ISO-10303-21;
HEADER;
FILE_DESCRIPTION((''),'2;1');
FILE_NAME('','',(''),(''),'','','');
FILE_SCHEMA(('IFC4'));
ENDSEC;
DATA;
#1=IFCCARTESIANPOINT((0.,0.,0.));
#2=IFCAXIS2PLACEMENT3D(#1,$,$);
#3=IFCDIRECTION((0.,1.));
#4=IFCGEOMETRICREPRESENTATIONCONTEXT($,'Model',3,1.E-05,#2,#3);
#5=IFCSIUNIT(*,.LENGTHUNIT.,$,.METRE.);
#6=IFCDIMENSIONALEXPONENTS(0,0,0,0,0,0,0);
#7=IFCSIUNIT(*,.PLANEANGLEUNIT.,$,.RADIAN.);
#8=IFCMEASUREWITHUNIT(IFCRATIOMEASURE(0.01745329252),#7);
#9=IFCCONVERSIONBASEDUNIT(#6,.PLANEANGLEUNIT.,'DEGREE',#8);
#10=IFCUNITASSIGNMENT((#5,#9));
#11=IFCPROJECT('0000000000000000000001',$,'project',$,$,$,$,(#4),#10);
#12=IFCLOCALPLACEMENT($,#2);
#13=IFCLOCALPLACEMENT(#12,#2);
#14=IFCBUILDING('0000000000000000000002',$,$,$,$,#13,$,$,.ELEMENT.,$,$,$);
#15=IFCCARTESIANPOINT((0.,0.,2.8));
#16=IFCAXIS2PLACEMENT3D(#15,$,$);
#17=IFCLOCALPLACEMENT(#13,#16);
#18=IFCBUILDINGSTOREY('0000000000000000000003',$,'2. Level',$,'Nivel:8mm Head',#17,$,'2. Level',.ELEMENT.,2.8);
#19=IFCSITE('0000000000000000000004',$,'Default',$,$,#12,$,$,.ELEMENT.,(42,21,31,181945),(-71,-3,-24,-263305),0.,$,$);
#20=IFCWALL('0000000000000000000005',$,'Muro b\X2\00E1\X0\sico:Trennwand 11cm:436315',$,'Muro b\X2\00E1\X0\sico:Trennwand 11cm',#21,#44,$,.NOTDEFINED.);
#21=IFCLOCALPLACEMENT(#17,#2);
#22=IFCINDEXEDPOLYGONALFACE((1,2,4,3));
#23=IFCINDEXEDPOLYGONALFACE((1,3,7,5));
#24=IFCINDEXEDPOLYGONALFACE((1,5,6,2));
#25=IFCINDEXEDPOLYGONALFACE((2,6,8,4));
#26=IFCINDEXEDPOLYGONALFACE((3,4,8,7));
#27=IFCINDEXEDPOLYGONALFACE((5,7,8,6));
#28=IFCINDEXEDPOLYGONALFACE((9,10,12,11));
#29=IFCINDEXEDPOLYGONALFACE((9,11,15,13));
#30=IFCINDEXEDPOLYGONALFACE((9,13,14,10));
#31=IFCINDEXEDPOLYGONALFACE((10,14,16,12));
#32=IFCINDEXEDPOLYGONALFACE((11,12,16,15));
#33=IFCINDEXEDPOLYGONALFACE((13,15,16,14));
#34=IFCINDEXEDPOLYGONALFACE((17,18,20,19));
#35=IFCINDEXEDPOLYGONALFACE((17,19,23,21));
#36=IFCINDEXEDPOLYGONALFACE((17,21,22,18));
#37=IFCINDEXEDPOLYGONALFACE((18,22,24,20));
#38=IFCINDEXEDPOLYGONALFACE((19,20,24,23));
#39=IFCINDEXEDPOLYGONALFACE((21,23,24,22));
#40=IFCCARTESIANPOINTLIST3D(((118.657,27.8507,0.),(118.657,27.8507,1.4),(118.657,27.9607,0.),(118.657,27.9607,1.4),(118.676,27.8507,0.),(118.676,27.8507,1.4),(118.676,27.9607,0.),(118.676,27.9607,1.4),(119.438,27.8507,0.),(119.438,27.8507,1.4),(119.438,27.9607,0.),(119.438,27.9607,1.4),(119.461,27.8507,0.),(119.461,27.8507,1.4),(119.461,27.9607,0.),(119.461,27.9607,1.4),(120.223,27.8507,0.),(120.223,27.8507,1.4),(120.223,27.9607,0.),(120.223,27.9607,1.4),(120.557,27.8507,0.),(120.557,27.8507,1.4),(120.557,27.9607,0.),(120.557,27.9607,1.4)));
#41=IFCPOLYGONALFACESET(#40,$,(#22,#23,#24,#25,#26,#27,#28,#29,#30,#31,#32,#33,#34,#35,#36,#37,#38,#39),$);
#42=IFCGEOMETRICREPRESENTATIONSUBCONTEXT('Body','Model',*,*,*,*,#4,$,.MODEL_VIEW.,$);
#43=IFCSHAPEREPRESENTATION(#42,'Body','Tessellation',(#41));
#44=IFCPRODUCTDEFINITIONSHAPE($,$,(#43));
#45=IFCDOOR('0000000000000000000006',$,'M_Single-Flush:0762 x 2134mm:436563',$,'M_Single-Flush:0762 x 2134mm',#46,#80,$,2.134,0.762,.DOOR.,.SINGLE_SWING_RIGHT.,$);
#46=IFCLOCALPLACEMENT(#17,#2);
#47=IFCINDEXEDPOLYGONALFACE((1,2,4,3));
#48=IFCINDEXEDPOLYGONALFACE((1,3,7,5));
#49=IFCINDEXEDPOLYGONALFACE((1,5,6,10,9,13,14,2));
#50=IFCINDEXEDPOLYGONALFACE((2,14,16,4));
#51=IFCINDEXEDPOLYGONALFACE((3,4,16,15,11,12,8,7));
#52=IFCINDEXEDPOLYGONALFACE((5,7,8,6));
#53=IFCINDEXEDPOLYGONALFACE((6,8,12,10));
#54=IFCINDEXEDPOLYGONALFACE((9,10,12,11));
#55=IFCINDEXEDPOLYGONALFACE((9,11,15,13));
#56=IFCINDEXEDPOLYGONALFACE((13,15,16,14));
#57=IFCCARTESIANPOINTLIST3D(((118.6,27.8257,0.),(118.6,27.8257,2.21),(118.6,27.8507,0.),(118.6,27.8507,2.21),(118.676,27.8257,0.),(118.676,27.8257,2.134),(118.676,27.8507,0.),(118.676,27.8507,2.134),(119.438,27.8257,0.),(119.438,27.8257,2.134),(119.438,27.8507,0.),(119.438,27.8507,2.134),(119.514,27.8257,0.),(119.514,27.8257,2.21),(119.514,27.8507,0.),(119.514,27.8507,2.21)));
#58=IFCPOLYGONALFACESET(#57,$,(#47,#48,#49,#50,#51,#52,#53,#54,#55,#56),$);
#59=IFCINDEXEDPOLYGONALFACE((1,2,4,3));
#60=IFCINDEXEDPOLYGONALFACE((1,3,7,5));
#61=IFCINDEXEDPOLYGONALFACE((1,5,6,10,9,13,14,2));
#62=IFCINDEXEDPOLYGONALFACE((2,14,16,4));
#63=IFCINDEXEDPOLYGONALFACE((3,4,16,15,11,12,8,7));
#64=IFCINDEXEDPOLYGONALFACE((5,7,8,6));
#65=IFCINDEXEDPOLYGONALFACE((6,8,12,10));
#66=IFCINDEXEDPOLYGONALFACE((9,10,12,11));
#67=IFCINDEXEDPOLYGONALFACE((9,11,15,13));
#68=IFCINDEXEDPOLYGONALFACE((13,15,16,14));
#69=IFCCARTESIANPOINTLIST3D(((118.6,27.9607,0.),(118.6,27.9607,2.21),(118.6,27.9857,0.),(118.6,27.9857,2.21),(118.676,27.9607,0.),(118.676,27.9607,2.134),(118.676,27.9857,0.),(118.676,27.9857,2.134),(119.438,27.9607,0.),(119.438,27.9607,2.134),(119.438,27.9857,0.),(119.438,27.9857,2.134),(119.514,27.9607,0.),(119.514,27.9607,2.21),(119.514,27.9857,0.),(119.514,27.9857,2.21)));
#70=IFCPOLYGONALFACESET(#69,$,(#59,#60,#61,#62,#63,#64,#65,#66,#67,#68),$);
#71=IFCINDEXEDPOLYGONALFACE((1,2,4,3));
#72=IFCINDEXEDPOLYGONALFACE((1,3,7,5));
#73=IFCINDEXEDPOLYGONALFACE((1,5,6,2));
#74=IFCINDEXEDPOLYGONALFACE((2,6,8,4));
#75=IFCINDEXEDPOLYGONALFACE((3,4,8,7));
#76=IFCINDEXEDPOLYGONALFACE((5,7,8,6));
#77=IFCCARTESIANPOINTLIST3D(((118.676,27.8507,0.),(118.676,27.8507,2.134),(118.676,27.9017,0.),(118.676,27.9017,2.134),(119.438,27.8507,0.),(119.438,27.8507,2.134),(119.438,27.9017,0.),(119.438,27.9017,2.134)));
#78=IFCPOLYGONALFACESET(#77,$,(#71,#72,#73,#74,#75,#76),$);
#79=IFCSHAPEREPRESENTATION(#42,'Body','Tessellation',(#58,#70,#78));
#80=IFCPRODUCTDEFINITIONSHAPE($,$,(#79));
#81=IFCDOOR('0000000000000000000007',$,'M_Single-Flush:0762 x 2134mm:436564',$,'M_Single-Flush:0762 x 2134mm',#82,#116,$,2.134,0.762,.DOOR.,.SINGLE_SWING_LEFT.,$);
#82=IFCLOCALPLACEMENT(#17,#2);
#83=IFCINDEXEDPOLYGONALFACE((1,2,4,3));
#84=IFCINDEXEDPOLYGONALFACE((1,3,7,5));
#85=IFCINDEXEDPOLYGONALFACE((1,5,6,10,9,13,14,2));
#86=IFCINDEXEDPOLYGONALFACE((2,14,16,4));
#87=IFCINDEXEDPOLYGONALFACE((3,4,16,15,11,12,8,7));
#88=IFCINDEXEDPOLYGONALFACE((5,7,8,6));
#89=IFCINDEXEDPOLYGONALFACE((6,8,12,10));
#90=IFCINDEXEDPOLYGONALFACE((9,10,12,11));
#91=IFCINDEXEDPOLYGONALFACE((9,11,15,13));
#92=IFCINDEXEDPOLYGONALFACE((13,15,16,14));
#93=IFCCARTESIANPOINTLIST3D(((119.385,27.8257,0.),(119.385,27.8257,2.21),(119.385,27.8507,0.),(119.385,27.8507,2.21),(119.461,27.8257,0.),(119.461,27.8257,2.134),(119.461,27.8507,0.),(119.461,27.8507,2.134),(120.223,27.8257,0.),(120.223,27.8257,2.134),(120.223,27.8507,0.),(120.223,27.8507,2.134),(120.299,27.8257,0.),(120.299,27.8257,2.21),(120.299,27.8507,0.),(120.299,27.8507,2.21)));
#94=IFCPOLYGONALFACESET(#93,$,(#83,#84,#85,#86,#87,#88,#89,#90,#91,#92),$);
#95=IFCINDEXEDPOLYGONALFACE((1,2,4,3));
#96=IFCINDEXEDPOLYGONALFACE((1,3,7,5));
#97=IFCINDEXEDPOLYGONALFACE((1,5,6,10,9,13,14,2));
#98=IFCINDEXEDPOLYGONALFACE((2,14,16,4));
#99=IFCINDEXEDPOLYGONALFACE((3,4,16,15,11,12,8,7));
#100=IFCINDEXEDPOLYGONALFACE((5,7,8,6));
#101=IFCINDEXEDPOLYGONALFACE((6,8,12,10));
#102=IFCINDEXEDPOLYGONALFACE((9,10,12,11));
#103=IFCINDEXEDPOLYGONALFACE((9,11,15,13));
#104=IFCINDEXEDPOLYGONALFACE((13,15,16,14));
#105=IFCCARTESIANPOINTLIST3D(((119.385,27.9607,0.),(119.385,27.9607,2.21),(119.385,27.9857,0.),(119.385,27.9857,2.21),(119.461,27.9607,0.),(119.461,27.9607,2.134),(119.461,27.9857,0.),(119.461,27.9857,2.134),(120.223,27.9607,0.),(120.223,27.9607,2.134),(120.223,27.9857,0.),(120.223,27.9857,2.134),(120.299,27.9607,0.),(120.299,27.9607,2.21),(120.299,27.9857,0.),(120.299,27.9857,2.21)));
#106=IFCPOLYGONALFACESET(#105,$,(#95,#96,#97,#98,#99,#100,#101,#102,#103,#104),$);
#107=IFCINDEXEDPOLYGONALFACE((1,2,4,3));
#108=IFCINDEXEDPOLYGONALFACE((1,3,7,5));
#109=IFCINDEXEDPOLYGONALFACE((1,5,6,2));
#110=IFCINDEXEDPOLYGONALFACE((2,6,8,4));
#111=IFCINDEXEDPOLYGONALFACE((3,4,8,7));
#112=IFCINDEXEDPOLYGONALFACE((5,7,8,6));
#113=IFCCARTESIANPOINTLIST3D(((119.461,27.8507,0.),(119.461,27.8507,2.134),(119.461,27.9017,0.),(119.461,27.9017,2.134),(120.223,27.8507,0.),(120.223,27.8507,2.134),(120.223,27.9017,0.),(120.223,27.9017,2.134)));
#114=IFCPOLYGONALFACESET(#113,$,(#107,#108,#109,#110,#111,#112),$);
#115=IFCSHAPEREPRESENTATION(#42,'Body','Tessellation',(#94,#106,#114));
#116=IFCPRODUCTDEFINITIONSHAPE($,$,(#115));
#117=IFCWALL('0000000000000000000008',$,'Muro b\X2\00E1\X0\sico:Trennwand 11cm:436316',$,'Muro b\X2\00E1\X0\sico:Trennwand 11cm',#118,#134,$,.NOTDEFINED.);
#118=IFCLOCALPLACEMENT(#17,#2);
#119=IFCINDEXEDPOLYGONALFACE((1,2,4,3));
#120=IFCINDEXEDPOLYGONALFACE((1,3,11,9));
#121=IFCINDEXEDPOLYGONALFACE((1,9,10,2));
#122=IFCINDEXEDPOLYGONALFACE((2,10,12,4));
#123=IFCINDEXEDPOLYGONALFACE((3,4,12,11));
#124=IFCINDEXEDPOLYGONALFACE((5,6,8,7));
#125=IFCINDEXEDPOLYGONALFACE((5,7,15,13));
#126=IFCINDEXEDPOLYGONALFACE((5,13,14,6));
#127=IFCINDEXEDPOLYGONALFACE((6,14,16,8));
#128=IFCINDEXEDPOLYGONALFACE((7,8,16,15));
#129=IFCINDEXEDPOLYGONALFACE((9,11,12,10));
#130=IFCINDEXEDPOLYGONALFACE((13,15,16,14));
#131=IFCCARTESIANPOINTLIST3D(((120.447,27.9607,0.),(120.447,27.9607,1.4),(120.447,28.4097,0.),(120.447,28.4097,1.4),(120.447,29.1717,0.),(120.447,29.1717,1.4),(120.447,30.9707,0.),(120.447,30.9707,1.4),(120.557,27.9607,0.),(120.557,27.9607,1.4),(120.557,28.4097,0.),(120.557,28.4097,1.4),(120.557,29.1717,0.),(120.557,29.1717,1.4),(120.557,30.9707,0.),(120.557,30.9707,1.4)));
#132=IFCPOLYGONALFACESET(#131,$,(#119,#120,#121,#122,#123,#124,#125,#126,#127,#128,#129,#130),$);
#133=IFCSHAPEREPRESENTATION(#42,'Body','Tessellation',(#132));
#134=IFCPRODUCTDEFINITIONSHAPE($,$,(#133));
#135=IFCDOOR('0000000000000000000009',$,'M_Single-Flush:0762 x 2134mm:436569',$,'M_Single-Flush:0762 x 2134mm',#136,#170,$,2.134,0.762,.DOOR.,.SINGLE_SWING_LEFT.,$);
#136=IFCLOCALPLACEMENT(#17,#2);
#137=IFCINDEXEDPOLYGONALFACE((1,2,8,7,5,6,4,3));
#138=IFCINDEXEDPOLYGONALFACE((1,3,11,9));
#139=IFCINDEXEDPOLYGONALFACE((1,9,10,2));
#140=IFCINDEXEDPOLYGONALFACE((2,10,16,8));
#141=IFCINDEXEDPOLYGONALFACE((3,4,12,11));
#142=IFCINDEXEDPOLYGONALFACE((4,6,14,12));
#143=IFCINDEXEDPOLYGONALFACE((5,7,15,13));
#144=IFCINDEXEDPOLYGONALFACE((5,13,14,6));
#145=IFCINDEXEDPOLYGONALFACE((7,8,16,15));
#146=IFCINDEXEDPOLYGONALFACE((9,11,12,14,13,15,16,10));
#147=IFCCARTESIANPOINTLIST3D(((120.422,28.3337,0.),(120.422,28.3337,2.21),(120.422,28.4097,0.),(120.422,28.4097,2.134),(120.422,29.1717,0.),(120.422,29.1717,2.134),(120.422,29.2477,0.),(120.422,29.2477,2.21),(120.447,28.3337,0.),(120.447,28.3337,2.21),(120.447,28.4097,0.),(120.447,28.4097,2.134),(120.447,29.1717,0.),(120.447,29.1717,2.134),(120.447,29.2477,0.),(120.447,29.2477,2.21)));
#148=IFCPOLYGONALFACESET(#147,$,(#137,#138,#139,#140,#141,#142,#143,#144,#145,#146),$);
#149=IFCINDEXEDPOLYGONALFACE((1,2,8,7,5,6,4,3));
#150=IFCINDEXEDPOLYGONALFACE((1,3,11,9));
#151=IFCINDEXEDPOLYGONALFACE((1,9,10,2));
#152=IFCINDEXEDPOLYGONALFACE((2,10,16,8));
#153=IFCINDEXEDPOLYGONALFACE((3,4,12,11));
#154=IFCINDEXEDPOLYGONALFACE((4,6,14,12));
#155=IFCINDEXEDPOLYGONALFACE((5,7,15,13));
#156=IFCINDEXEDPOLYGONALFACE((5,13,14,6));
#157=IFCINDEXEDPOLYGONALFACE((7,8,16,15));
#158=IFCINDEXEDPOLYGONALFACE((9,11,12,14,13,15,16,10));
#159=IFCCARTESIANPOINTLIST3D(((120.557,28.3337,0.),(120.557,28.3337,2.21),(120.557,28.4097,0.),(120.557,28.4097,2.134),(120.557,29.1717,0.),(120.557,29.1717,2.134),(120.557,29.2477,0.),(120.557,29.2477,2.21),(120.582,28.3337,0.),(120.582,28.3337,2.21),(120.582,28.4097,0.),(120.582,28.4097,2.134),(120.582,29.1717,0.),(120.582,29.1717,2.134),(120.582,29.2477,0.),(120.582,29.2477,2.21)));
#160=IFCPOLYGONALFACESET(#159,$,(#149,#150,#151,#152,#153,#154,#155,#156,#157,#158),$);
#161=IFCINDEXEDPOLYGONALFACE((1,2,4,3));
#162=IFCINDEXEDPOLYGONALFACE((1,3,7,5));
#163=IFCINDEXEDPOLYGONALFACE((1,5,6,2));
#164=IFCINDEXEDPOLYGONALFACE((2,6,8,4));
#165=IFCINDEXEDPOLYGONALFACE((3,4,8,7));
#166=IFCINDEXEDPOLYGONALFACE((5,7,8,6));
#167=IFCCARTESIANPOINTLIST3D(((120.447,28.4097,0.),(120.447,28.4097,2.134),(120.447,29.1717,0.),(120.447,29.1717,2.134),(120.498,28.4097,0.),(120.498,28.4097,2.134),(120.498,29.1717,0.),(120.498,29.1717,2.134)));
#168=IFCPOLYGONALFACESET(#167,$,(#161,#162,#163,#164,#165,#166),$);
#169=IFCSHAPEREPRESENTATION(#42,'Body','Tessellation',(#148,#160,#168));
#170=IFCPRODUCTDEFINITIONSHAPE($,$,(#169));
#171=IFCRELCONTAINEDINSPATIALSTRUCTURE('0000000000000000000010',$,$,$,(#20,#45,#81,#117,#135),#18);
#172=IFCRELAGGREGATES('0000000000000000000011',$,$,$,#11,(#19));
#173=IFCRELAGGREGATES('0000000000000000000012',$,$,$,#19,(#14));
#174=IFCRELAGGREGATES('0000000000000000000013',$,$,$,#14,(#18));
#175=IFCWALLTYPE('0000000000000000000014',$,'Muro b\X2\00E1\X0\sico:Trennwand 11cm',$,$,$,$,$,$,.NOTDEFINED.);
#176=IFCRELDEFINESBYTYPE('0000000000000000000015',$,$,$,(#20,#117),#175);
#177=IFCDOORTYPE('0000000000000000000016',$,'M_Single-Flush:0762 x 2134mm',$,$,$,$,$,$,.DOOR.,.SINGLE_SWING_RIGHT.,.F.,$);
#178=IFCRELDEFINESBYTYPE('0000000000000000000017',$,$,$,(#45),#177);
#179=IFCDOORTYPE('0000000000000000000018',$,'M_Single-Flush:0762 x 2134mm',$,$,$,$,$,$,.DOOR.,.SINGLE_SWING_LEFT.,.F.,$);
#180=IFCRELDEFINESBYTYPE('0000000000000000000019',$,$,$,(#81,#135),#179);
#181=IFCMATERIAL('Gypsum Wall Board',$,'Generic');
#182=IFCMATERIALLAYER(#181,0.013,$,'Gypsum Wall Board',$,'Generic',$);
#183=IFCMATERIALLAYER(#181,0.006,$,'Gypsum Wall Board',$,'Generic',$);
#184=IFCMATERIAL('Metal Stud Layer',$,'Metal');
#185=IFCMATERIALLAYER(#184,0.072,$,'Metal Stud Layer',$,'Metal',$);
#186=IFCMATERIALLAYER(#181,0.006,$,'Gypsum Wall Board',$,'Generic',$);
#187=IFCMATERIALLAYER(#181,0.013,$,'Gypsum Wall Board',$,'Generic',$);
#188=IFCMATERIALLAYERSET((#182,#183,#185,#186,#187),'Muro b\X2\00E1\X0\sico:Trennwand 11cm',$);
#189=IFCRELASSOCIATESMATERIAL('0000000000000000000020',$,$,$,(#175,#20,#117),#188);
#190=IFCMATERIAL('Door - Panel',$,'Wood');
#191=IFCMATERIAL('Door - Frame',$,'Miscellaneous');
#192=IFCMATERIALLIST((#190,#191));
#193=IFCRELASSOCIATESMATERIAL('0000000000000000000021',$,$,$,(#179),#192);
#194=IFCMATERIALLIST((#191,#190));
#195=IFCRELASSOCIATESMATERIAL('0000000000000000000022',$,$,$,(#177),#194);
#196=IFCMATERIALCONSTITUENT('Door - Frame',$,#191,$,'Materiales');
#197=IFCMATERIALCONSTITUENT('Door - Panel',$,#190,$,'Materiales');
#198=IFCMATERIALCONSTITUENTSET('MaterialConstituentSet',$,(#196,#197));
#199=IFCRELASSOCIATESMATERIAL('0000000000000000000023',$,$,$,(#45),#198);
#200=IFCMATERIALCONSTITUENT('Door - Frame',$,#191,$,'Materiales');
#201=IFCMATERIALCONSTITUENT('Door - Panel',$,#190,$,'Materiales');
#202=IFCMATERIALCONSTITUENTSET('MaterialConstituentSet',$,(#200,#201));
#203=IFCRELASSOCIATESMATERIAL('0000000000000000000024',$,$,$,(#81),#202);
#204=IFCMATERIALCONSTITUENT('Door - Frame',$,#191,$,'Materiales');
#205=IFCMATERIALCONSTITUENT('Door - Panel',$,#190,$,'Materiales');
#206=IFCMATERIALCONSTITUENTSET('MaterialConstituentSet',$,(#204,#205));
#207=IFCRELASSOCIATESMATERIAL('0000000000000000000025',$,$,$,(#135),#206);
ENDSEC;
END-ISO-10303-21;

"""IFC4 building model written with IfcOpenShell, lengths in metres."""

from ifc_helpers import new_model, entity, si_unit, converted_unit, direction, frame, frame_2d, origin, origin_2d_with_axis, place, context, subcontext, project, spatial, polyline, rectangle, outline, extrude, clip, halfspace, source, transform, mapped, material, material_list, layer, layer_set, layer_usage, constituent, constituent_set, type_object, type_shapes, element, fill, save


model = new_model("IFC4")

# Units and contexts
model_context = context("Model", 3, precision=1e-05, world=origin(), true_north=direction((0.0, 1.0)))
body_context = subcontext(model_context, "Body", "Model", "MODEL_VIEW")
ifc_project = project(units=[si_unit("LENGTHUNIT", "METRE"), converted_unit("PLANEANGLEUNIT", "DEGREE", entity("IfcRatioMeasure", 0.01745329252), si_unit("PLANEANGLEUNIT", "RADIAN"), dimensions=[0, 0, 0, 0, 0, 0, 0])], contexts=[model_context])

# Site, building, storey
site_placement = place(None, origin())
site = spatial("IfcSite", under=ifc_project, at=site_placement, Name="Default", CompositionType="ELEMENT", RefLatitude=(42, 21, 31, 181945), RefLongitude=(-71, -3, -24, -263305), RefElevation=0.0)
building_placement = place(site_placement, origin())
building = spatial("IfcBuilding", under=site, at=building_placement, CompositionType="ELEMENT")
storey_placement = place(building_placement, frame((0.0, 0.0, 2.8)))
storey = spatial("IfcBuildingStorey", under=building, at=storey_placement, Name="2. Level", ObjectType="Nivel:8mm Head", LongName="2. Level", CompositionType="ELEMENT", Elevation=2.8)

# Shared definitions
ifc_material_1 = material(Name="Gypsum Wall Board", Category="Generic")
ifc_layer_1 = layer(ifc_material_1, 0.013, Name="Gypsum Wall Board", Category="Generic")
ifc_layer_2 = layer(ifc_material_1, 0.006, Name="Gypsum Wall Board", Category="Generic")
ifc_material_2 = material(Name="Metal Stud Layer", Category="Metal")
ifc_layer_3 = layer(ifc_material_2, 0.072, Name="Metal Stud Layer", Category="Metal")
ifc_layer_4 = layer(ifc_material_1, 0.006, Name="Gypsum Wall Board", Category="Generic")
ifc_layer_5 = layer(ifc_material_1, 0.013, Name="Gypsum Wall Board", Category="Generic")
ifc_layer_set_1 = layer_set([ifc_layer_1, ifc_layer_2, ifc_layer_3, ifc_layer_4, ifc_layer_5], Name="Muro básico:Trennwand 11cm")
wall_type_1 = type_object("IfcWallType", Name="Muro básico:Trennwand 11cm", PredefinedType="NOTDEFINED", material=ifc_layer_set_1)
ifc_material_3 = material(Name="Door - Frame", Category="Miscellaneous")
ifc_material_4 = material(Name="Door - Panel", Category="Wood")
ifc_material_list_1 = material_list([ifc_material_4, ifc_material_3])
door_type_1 = type_object("IfcDoorType", Name="M_Single-Flush:0762 x 2134mm", OperationType="SINGLE_SWING_LEFT", ParameterTakesPrecedence=False, PredefinedType="DOOR", material=ifc_material_list_1)
shared_shape_1 = source(origin(), body_context, "Body", "SweptSolid", [
    extrude(outline(polyline([(-0.457, -1.124), (0.457, -1.124), (0.457, 1.086), (0.381, 1.086), (0.381, -1.048), (-0.381, -1.048), (-0.381, 1.086), (-0.457, 1.086), (-0.457, -1.124)])), frame((0.381, 0.135, 1.086), z_axis=(0.0, -1.0, 0.0), x_axis=(-1.0, 0.0, 0.0)), (0.0, 0.0, 1.0), 0.025),
    extrude(outline(polyline([(-1.124, -0.457), (1.086, -0.457), (1.086, -0.381), (-1.048, -0.381), (-1.048, 0.381), (1.086, 0.381), (1.086, 0.457), (-1.124, 0.457), (-1.124, -0.457)])), frame((0.381, 0.0, 1.086), z_axis=(0.0, -1.0, 0.0), x_axis=(0.0, 0.0, -1.0)), (0.0, 0.0, 1.0), 0.025),
    extrude(rectangle(XDim=0.762, YDim=0.051, at=origin_2d_with_axis()), frame((0.381, 0.0845, 0.0)), (0.0, 0.0, 1.0), 2.134),
])
type_shapes(door_type_1, [shared_shape_1])

# Wall, openings, doors
ifc_layer_usage_1 = layer_usage(ifc_layer_set_1, "AXIS2", "NEGATIVE", 0.055)
wall_1_placement = place(storey_placement, frame((118.657, 27.9057, 0.0)))
wall_1 = element("IfcWall", 1, at=wall_1_placement, inside=storey, type_object=wall_type_1, material=ifc_layer_usage_1, Name="Muro básico:Trennwand 11cm:436315", ObjectType="Muro básico:Trennwand 11cm", PredefinedType="NOTDEFINED", context=body_context, shape_type="Clipping", body=[
    clip(extrude(rectangle(XDim=1.9, YDim=0.11, at=frame_2d((0.95, 0.0), x_axis=(-1.0, 0.0))), origin(), (0.0, 0.0, 1.0), 1.4), halfspace(origin(), True)),
])
opening_1_placement = place(wall_1_placement, frame((0.781, 0.055, 0.0)))
opening_1 = element("IfcOpeningElement", 2, at=opening_1_placement, cuts=wall_1, ObjectType="Opening", PredefinedType="OPENING", context=body_context, shape_type="SweptSolid", body=[
    extrude(rectangle(XDim=0.762, YDim=2.134, at=frame_2d((1.067, 0.381), x_axis=(0.0, 1.0))), frame((0.0, 0.0, 0.0), z_axis=(0.0, -1.0, 0.0), x_axis=(0.0, 0.0, 1.0)), (0.0, 0.0, 1.0), 0.11),
])
opening_2_placement = place(wall_1_placement, frame((1.566, 0.055, 0.0)))
opening_2 = element("IfcOpeningElement", 3, at=opening_2_placement, cuts=wall_1, ObjectType="Opening", PredefinedType="OPENING", context=body_context, shape_type="SweptSolid", body=[
    extrude(rectangle(XDim=0.762, YDim=2.134, at=frame_2d((1.067, 0.381), x_axis=(0.0, -1.0))), frame((0.0, 0.0, 0.0), z_axis=(0.0, -1.0, 0.0), x_axis=(0.0, 0.0, 1.0)), (0.0, 0.0, 1.0), 0.11),
])
ifc_constituent_1 = constituent(ifc_material_3, Name="Door - Frame", Category="Materiales")
ifc_constituent_2 = constituent(ifc_material_4, Name="Door - Panel", Category="Materiales")
ifc_constituent_set_1 = constituent_set(constituents=[ifc_constituent_1, ifc_constituent_2], Name="MaterialConstituentSet")
ifc_material_list_2 = material_list([ifc_material_3, ifc_material_4])
door_type_2 = type_object("IfcDoorType", Name="M_Single-Flush:0762 x 2134mm", OperationType="SINGLE_SWING_RIGHT", ParameterTakesPrecedence=False, PredefinedType="DOOR", material=ifc_material_list_2)
shared_shape_2 = source(origin(), body_context, "Body", "SweptSolid", [
    extrude(outline(polyline([(-0.457, -1.124), (0.457, -1.124), (0.457, 1.086), (0.381, 1.086), (0.381, -1.048), (-0.381, -1.048), (-0.381, 1.086), (-0.457, 1.086), (-0.457, -1.124)])), frame((0.381, 0.11, 1.086), z_axis=(0.0, 1.0, 0.0), x_axis=(1.0, 0.0, 0.0)), (0.0, 0.0, 1.0), 0.025),
    extrude(outline(polyline([(-1.124, -0.457), (1.086, -0.457), (1.086, -0.381), (-1.048, -0.381), (-1.048, 0.381), (1.086, 0.381), (1.086, 0.457), (-1.124, 0.457), (-1.124, -0.457)])), frame((0.381, -0.025, 1.086), z_axis=(0.0, 1.0, 0.0), x_axis=(0.0, 0.0, -1.0)), (0.0, 0.0, 1.0), 0.025),
    extrude(rectangle(XDim=0.051, YDim=0.762, at=origin_2d_with_axis()), frame((0.381, 0.0845, 0.0), z_axis=(0.0, 0.0, 1.0), x_axis=(0.0, 1.0, 0.0)), (0.0, 0.0, 1.0), 2.134),
])
type_shapes(door_type_2, [shared_shape_2])
door_1_placement = place(opening_1_placement, frame((0.0, 0.0, 0.0), z_axis=(0.0, 0.0, 1.0), x_axis=(-1.0, 0.0, 0.0)))
door_1 = element("IfcDoor", 4, at=door_1_placement, inside=storey, type_object=door_type_2, material=ifc_constituent_set_1, Name="M_Single-Flush:0762 x 2134mm:436563", ObjectType="M_Single-Flush:0762 x 2134mm", OperationType="SINGLE_SWING_RIGHT", OverallHeight=2.134, OverallWidth=0.762, PredefinedType="DOOR", context=body_context, shape_type="MappedRepresentation", body=[
    mapped(shared_shape_2, transform((0.0, 0.0, 0.0), scale=1.0)),
])
fill(opening_1, door_1)
ifc_constituent_3 = constituent(ifc_material_3, Name="Door - Frame", Category="Materiales")
ifc_constituent_4 = constituent(ifc_material_4, Name="Door - Panel", Category="Materiales")
ifc_constituent_set_2 = constituent_set(constituents=[ifc_constituent_3, ifc_constituent_4], Name="MaterialConstituentSet")
door_2_placement = place(opening_2_placement, frame((0.0, 0.0, 0.0), z_axis=(0.0, 0.0, 1.0), x_axis=(-1.0, 0.0, 0.0)))
door_2 = element("IfcDoor", 5, at=door_2_placement, inside=storey, type_object=door_type_1, material=ifc_constituent_set_2, Name="M_Single-Flush:0762 x 2134mm:436564", ObjectType="M_Single-Flush:0762 x 2134mm", OperationType="SINGLE_SWING_LEFT", OverallHeight=2.134, OverallWidth=0.762, PredefinedType="DOOR", context=body_context, shape_type="MappedRepresentation", body=[
    mapped(shared_shape_1, transform((0.0, 0.0, 0.0), scale=1.0)),
])
fill(opening_2, door_2)

# Wall, opening, door
ifc_layer_usage_2 = layer_usage(ifc_layer_set_1, "AXIS2", "NEGATIVE", 0.055)
wall_2_placement = place(storey_placement, frame((120.502, 27.9607, 0.0), z_axis=(0.0, 0.0, 1.0), x_axis=(0.0, 1.0, 0.0)))
wall_2 = element("IfcWall", 6, at=wall_2_placement, inside=storey, type_object=wall_type_1, material=ifc_layer_usage_2, Name="Muro básico:Trennwand 11cm:436316", ObjectType="Muro básico:Trennwand 11cm", PredefinedType="NOTDEFINED", context=body_context, shape_type="Clipping", body=[
    clip(extrude(rectangle(XDim=3.01, YDim=0.11, at=frame_2d((1.505, 0.0), x_axis=(-1.0, 0.0))), origin(), (0.0, 0.0, 1.0), 1.4), halfspace(origin(), True)),
])
opening_3_placement = place(wall_2_placement, frame((0.449, -0.055, 0.0)))
opening_3 = element("IfcOpeningElement", 7, at=opening_3_placement, cuts=wall_2, ObjectType="Opening", PredefinedType="OPENING", context=body_context, shape_type="SweptSolid", body=[
    extrude(rectangle(XDim=0.762, YDim=2.134, at=frame_2d((1.067, 0.381), x_axis=(0.0, -1.0))), frame((0.0, 0.0, 0.0), z_axis=(0.0, 1.0, 0.0), x_axis=(0.0, 0.0, 1.0)), (0.0, 0.0, 1.0), 0.11),
])
ifc_constituent_5 = constituent(ifc_material_3, Name="Door - Frame", Category="Materiales")
ifc_constituent_6 = constituent(ifc_material_4, Name="Door - Panel", Category="Materiales")
ifc_constituent_set_3 = constituent_set(constituents=[ifc_constituent_5, ifc_constituent_6], Name="MaterialConstituentSet")
door_3_placement = place(opening_3_placement, origin())
door_3 = element("IfcDoor", 8, at=door_3_placement, inside=storey, type_object=door_type_1, material=ifc_constituent_set_3, Name="M_Single-Flush:0762 x 2134mm:436569", ObjectType="M_Single-Flush:0762 x 2134mm", OperationType="SINGLE_SWING_LEFT", OverallHeight=2.134, OverallWidth=0.762, PredefinedType="DOOR", context=body_context, shape_type="MappedRepresentation", body=[
    mapped(shared_shape_1, transform((0.0, 0.0, 0.0), scale=1.0)),
])
fill(opening_3, door_3)

save(model, "model.ifc")
